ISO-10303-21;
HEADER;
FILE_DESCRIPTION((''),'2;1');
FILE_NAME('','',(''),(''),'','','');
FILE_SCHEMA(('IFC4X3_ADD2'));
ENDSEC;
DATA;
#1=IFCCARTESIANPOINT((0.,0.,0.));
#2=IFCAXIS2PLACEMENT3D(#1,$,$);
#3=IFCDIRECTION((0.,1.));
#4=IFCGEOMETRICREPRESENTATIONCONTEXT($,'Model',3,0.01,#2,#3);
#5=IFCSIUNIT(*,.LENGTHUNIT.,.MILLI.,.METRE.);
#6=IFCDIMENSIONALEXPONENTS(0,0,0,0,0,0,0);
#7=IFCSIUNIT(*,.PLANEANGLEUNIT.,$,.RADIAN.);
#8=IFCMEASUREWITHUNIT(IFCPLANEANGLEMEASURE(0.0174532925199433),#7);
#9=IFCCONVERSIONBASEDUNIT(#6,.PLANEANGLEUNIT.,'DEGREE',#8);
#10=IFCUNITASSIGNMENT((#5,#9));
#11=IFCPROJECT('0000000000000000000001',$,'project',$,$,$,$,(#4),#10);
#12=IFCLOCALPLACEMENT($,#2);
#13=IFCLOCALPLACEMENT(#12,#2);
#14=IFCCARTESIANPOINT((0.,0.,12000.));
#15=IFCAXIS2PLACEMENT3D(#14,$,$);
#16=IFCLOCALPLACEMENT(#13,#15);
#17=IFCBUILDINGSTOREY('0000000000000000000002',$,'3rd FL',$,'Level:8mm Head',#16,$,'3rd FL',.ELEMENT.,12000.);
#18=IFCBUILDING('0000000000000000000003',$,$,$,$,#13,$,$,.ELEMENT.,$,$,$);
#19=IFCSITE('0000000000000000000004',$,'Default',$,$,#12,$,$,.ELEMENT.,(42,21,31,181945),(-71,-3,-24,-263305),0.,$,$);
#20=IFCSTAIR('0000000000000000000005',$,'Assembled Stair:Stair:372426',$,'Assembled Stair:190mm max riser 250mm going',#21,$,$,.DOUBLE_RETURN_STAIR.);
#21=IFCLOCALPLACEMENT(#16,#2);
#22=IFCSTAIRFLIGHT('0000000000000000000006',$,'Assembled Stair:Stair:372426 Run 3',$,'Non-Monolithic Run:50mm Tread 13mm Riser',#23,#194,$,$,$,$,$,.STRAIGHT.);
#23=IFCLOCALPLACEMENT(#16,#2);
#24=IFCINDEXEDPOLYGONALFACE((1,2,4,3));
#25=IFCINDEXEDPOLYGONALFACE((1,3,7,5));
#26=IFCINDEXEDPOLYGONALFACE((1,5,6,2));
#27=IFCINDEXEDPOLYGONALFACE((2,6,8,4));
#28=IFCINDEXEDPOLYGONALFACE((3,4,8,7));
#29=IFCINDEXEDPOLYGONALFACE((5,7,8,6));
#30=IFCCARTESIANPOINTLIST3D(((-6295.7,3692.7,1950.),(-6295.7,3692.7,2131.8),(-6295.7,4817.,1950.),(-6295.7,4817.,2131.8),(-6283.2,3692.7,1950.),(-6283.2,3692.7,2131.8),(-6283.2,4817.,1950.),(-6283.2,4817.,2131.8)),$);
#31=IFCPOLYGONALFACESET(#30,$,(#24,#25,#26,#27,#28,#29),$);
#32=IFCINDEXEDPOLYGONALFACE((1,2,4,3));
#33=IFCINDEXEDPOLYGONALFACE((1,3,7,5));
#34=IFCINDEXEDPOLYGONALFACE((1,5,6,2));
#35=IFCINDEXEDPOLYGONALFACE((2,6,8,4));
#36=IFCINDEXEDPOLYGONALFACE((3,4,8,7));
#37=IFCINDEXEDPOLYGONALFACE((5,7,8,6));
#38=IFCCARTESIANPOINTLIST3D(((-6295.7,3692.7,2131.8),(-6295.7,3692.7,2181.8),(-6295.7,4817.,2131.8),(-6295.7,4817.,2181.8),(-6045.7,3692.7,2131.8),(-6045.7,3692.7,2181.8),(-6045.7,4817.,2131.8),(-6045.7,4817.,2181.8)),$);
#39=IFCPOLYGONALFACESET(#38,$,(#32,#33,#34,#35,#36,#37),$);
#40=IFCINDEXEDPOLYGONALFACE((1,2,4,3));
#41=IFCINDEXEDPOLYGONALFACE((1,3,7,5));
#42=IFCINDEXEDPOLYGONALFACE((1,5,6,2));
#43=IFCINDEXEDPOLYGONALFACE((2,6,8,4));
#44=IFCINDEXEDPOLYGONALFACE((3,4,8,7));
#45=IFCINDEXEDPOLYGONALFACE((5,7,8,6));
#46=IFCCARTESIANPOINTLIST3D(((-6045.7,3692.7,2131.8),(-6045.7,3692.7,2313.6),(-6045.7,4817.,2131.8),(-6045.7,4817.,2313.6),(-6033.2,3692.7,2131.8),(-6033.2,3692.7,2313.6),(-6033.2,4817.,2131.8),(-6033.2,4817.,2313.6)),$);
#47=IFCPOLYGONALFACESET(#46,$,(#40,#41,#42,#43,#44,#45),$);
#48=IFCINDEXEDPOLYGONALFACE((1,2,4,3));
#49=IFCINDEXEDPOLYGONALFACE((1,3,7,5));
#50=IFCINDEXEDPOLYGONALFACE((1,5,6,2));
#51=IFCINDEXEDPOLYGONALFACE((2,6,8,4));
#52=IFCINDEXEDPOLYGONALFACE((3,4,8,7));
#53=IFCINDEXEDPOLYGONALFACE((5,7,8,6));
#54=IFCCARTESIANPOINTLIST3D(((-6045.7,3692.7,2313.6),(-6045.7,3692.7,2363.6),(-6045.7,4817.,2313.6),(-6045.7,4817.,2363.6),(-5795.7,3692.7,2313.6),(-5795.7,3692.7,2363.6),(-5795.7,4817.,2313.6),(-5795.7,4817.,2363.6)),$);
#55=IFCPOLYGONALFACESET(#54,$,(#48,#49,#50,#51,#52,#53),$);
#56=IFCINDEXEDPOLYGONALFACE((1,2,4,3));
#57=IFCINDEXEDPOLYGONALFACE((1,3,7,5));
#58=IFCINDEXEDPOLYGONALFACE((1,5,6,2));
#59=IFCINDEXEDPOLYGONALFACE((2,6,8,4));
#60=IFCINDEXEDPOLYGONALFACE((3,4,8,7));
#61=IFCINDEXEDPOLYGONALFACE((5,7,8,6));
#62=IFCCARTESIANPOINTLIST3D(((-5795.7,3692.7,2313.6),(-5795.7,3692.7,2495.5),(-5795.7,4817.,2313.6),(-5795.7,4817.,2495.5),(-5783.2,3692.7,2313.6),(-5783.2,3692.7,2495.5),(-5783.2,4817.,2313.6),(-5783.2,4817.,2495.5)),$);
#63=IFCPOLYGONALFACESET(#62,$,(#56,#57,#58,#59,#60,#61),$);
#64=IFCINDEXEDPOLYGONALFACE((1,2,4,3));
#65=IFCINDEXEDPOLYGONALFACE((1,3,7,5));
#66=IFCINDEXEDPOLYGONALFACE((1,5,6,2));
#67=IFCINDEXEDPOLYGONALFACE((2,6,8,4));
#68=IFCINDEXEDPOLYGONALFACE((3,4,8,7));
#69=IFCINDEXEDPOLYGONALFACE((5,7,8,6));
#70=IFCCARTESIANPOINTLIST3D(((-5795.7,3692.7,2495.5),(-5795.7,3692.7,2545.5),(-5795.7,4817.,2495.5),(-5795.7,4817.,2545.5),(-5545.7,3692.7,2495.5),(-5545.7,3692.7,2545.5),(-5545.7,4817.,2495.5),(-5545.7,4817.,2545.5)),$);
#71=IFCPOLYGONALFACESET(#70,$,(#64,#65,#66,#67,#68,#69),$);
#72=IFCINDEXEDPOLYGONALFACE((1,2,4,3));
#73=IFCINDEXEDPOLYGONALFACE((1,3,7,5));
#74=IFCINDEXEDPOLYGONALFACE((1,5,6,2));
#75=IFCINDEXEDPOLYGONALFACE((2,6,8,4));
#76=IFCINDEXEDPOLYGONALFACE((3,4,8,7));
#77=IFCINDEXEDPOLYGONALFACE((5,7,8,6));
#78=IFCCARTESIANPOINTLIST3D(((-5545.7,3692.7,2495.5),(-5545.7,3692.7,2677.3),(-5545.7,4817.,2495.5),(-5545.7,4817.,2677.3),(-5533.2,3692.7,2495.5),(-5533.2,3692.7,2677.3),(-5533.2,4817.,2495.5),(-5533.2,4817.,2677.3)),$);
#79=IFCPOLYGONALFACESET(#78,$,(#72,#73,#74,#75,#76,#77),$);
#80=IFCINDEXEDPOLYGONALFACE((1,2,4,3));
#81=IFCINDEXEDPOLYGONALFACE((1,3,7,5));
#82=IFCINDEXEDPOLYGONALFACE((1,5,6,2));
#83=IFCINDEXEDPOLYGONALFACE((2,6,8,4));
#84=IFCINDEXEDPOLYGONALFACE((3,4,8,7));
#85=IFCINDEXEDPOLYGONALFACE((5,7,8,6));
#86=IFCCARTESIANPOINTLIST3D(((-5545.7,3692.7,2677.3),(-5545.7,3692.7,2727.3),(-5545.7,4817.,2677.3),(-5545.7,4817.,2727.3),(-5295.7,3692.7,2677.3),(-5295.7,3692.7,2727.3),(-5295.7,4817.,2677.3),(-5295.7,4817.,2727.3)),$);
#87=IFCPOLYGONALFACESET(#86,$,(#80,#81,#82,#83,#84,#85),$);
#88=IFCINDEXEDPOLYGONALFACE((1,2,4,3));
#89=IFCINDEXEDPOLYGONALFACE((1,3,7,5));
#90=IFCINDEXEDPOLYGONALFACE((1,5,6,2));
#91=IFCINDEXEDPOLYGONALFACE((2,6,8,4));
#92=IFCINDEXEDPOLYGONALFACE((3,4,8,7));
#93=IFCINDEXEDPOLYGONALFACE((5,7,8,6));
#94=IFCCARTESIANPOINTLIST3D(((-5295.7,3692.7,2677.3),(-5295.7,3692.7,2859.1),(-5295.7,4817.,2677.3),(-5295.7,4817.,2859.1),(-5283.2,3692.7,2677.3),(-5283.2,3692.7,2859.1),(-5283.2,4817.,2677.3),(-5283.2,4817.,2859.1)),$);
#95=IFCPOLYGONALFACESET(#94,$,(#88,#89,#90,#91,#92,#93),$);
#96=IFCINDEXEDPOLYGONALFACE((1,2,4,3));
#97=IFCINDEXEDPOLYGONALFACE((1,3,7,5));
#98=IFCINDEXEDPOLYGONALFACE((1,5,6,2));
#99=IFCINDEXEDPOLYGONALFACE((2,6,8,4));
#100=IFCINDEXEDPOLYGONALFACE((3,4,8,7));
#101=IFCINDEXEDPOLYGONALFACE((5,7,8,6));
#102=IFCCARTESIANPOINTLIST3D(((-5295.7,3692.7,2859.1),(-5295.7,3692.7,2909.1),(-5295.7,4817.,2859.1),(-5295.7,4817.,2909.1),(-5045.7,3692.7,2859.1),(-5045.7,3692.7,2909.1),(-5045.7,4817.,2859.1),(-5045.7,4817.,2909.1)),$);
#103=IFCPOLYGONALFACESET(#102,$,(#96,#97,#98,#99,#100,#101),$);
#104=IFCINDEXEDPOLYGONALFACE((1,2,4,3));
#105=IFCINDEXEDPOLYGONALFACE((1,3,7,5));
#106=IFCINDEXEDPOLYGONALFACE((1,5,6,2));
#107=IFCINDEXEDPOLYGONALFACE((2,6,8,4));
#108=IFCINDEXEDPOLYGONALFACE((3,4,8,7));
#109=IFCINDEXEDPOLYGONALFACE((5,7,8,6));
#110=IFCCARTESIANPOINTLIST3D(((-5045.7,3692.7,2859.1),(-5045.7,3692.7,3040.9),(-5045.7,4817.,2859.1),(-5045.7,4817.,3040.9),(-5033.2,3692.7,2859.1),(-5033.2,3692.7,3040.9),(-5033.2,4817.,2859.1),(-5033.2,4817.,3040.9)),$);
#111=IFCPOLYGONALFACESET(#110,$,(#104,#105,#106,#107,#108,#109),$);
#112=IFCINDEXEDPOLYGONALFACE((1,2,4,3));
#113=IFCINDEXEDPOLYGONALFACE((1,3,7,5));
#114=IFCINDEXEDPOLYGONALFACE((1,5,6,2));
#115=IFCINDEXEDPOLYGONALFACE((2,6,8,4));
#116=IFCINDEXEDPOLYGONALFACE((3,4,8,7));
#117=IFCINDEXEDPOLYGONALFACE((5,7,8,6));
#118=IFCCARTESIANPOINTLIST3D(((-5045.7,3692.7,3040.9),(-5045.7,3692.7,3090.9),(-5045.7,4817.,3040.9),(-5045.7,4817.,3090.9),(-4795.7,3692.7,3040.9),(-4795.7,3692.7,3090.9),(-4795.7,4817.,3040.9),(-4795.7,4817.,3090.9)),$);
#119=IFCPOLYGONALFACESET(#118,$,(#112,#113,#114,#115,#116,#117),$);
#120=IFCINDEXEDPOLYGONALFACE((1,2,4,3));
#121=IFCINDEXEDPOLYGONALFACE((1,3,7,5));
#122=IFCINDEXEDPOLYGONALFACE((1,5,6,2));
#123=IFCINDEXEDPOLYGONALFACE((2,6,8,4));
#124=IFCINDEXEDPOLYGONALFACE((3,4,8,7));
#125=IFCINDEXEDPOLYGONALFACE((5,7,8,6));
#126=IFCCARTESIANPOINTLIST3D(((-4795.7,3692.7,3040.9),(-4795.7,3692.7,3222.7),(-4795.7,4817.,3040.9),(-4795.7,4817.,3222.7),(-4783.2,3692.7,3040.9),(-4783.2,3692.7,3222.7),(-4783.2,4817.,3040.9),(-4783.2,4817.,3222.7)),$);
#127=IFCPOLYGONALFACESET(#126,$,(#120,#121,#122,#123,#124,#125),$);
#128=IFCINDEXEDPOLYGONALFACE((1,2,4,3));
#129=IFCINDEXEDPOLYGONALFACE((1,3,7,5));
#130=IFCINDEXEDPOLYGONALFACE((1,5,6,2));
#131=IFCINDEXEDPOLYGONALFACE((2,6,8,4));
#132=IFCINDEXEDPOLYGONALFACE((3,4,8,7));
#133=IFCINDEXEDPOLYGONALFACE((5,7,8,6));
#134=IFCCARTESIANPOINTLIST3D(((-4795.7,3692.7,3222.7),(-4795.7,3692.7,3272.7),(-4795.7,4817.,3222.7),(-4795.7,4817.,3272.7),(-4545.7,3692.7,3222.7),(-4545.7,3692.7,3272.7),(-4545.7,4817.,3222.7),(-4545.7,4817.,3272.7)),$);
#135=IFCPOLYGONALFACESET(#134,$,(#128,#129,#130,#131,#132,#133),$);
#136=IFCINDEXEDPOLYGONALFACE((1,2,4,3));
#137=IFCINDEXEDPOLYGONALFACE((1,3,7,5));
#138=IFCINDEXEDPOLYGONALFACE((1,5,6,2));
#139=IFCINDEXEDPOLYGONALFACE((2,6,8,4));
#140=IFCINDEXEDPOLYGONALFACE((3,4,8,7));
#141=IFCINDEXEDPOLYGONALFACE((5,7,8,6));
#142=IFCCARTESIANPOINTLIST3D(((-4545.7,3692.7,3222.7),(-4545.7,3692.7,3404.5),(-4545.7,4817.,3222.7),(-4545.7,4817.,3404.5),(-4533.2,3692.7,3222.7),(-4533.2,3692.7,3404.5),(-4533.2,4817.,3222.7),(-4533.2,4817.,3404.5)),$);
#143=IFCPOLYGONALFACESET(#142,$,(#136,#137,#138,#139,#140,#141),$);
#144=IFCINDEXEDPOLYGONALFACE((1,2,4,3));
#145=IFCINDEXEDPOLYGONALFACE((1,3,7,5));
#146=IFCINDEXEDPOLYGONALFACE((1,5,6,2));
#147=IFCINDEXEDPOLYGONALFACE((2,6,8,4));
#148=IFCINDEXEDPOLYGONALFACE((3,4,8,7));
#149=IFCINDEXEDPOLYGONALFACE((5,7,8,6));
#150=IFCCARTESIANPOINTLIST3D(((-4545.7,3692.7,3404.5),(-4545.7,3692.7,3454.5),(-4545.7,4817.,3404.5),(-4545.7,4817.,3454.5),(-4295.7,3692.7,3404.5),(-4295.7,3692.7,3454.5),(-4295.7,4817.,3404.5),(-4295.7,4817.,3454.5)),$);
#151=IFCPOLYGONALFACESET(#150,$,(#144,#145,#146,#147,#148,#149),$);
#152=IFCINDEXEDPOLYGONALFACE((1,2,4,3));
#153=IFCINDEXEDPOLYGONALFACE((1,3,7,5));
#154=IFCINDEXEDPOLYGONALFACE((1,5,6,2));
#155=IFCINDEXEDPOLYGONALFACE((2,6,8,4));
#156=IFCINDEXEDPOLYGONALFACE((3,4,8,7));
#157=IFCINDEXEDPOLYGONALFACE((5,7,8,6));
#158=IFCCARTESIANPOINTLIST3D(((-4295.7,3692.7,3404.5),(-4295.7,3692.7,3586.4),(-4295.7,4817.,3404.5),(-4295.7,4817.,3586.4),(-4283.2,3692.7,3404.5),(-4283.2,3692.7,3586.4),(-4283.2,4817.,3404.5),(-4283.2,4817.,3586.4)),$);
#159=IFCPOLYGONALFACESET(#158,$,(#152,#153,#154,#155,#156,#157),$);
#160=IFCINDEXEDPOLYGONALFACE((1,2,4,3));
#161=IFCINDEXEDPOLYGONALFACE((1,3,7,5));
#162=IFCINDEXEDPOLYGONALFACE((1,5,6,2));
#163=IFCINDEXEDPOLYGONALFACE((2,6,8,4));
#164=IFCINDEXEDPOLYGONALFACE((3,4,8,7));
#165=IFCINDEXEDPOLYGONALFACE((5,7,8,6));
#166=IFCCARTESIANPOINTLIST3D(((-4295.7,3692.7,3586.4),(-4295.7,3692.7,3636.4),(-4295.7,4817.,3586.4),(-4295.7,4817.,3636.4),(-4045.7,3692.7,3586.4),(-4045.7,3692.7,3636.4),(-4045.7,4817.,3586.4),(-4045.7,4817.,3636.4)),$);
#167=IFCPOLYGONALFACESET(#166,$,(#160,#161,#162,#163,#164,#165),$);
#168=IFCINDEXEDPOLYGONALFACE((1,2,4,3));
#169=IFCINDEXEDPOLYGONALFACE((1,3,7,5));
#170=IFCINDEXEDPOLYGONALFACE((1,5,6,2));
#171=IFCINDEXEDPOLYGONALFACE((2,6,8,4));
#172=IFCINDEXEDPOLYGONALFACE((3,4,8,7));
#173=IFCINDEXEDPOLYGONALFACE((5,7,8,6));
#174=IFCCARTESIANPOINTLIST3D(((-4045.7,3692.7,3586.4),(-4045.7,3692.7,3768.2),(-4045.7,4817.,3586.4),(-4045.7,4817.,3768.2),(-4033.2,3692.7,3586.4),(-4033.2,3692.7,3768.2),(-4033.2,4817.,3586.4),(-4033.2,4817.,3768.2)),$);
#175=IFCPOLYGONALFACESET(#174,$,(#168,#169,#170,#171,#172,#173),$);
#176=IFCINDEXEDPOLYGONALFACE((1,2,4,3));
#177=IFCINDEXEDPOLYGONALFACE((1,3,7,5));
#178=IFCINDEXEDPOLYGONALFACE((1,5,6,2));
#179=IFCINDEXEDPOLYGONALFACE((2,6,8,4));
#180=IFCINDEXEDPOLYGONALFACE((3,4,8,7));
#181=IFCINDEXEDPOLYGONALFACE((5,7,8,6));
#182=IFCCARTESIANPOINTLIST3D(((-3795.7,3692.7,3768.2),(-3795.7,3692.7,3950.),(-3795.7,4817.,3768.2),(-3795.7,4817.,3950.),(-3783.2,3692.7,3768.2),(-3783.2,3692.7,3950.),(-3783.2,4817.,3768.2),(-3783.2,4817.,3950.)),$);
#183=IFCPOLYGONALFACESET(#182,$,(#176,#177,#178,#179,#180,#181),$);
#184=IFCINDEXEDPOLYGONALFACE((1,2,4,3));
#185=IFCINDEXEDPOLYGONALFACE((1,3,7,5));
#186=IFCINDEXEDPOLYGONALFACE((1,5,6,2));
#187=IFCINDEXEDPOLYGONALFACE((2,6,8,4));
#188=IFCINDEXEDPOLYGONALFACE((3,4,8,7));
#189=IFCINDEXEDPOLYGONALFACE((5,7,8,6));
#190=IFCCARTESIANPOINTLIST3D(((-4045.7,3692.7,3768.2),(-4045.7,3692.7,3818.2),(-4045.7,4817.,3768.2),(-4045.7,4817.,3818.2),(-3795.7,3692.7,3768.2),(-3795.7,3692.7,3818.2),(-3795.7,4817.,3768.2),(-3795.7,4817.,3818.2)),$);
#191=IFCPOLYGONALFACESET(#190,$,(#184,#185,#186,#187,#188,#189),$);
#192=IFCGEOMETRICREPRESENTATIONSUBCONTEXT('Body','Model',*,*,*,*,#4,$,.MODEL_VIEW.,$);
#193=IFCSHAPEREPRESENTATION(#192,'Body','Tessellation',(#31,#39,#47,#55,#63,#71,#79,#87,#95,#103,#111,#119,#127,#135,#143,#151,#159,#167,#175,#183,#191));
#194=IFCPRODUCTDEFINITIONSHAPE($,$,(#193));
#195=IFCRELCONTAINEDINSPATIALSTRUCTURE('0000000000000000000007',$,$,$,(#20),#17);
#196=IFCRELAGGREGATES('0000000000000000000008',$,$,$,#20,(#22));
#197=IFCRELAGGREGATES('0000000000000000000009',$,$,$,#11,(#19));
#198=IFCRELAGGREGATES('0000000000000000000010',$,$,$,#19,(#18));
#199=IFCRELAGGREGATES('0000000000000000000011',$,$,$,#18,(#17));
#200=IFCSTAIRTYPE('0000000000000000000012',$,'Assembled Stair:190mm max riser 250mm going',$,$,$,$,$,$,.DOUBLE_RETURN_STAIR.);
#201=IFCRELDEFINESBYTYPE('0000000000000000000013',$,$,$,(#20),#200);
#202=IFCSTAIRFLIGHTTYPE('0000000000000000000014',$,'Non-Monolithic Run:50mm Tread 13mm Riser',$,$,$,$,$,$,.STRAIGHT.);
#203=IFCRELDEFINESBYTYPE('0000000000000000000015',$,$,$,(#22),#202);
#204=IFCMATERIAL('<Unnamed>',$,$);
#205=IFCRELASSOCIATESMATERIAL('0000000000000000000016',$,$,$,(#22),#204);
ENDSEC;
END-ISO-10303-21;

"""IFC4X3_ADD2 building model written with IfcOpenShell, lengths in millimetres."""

from ifc_helpers import new_model, entity, si_unit, converted_unit, direction, frame, frame_2d, origin, origin_2d_with_axis, place, context, subcontext, project, spatial, rectangle, extrude, material, type_object, element, aggregate, save


model = new_model("IFC4X3_ADD2")

# Units and contexts
model_context = context("Model", 3, precision=0.01, world=origin(), true_north=direction((0.0, 1.0)))
body_context = subcontext(model_context, "Body", "Model", "MODEL_VIEW")
ifc_project = project(units=[si_unit("LENGTHUNIT", "METRE", prefix="MILLI"), converted_unit("PLANEANGLEUNIT", "DEGREE", entity("IfcPlaneAngleMeasure", 0.0174532925199433), si_unit("PLANEANGLEUNIT", "RADIAN"), dimensions=[0, 0, 0, 0, 0, 0, 0])], contexts=[model_context])

# Site, building, storey
site_placement = place(None, origin())
site = spatial("IfcSite", under=ifc_project, at=site_placement, Name="Default", CompositionType="ELEMENT", RefLatitude=(42, 21, 31, 181945), RefLongitude=(-71, -3, -24, -263305), RefElevation=0.0)
building_placement = place(site_placement, origin())
building = spatial("IfcBuilding", under=site, at=building_placement, CompositionType="ELEMENT")
storey_placement = place(building_placement, frame((0.0, 0.0, 12000.0)))
storey = spatial("IfcBuildingStorey", under=building, at=storey_placement, Name="3rd FL", ObjectType="Level:8mm Head", LongName="3rd FL", CompositionType="ELEMENT", Elevation=12000.0)

# Stair
stair_type = type_object("IfcStairType", Name="Assembled Stair:190mm max riser 250mm going", PredefinedType="DOUBLE_RETURN_STAIR")
stair_placement = place(storey_placement, origin())
stair = element("IfcStair", 1, at=stair_placement, inside=storey, type_object=stair_type, Name="Assembled Stair:Stair:372426", ObjectType="Assembled Stair:190mm max riser 250mm going", PredefinedType="DOUBLE_RETURN_STAIR")
ifc_material_1 = material(Name="<Unnamed>")

# Stair flight
stair_flight_type = type_object("IfcStairFlightType", Name="Non-Monolithic Run:50mm Tread 13mm Riser", PredefinedType="STRAIGHT")
stair_flight_1_placement = place(stair_placement, frame((-6295.7, 3692.7, 0.0)))
stair_flight_1 = element("IfcStairFlight", 2, at=stair_flight_1_placement, type_object=stair_flight_type, material=ifc_material_1, Name="Assembled Stair:Stair:372426 Run 3", ObjectType="Non-Monolithic Run:50mm Tread 13mm Riser", PredefinedType="STRAIGHT", context=body_context, shape_type="SweptSolid", body=[
    extrude(rectangle(XDim=1124.3, YDim=12.5, at=frame_2d((0.0, 0.0), x_axis=(1.0, 0.0))), frame((6.3, 562.2, 1950.0), z_axis=(0.0, 0.0, 1.0), x_axis=(0.0, 1.0, 0.0)), (0.0, 0.0, 1.0), 181.8),
    extrude(rectangle(XDim=250.0, YDim=1124.3, at=frame_2d((0.0, 0.0), x_axis=(1.0, 0.0))), frame((125.0, 562.2, 2131.8), z_axis=(0.0, 0.0, 1.0), x_axis=(-1.0, 0.0, 0.0)), (0.0, 0.0, 1.0), 50.0),
    extrude(rectangle(XDim=1124.3, YDim=12.5, at=frame_2d((0.0, 0.0), x_axis=(1.0, 0.0))), frame((256.3, 562.2, 2131.8), z_axis=(0.0, 0.0, 1.0), x_axis=(0.0, 1.0, 0.0)), (0.0, 0.0, 1.0), 181.8),
    extrude(rectangle(XDim=250.0, YDim=1124.3, at=frame_2d((0.0, 0.0), x_axis=(1.0, 0.0))), frame((375.0, 562.2, 2313.6), z_axis=(0.0, 0.0, 1.0), x_axis=(-1.0, 0.0, 0.0)), (0.0, 0.0, 1.0), 50.0),
    extrude(rectangle(XDim=1124.3, YDim=12.5, at=frame_2d((0.0, 0.0), x_axis=(1.0, 0.0))), frame((506.3, 562.2, 2313.6), z_axis=(0.0, 0.0, 1.0), x_axis=(0.0, 1.0, 0.0)), (0.0, 0.0, 1.0), 181.8),
    extrude(rectangle(XDim=250.0, YDim=1124.3, at=frame_2d((0.0, 0.0), x_axis=(1.0, 0.0))), frame((625.0, 562.2, 2495.5), z_axis=(0.0, 0.0, 1.0), x_axis=(-1.0, 0.0, 0.0)), (0.0, 0.0, 1.0), 50.0),
    extrude(rectangle(XDim=1124.3, YDim=12.5, at=frame_2d((0.0, 0.0), x_axis=(1.0, 0.0))), frame((756.3, 562.2, 2495.5), z_axis=(0.0, 0.0, 1.0), x_axis=(0.0, 1.0, 0.0)), (0.0, 0.0, 1.0), 181.8),
    extrude(rectangle(XDim=250.0, YDim=1124.3, at=frame_2d((0.0, 0.0), x_axis=(1.0, 0.0))), frame((875.0, 562.2, 2677.3), z_axis=(0.0, 0.0, 1.0), x_axis=(-1.0, 0.0, 0.0)), (0.0, 0.0, 1.0), 50.0),
    extrude(rectangle(XDim=1124.3, YDim=12.5, at=frame_2d((0.0, 0.0), x_axis=(1.0, 0.0))), frame((1006.2, 562.2, 2677.3), z_axis=(0.0, 0.0, 1.0), x_axis=(0.0, 1.0, 0.0)), (0.0, 0.0, 1.0), 181.8),
    extrude(rectangle(XDim=250.0, YDim=1124.3, at=frame_2d((0.0, 0.0), x_axis=(1.0, 0.0))), frame((1125.0, 562.2, 2859.1), z_axis=(0.0, 0.0, 1.0), x_axis=(-1.0, 0.0, 0.0)), (0.0, 0.0, 1.0), 50.0),
    extrude(rectangle(XDim=1124.3, YDim=12.5, at=frame_2d((0.0, 0.0), x_axis=(1.0, 0.0))), frame((1256.2, 562.2, 2859.1), z_axis=(0.0, 0.0, 1.0), x_axis=(0.0, 1.0, 0.0)), (0.0, 0.0, 1.0), 181.8),
    extrude(rectangle(XDim=250.0, YDim=1124.3, at=frame_2d((0.0, 0.0), x_axis=(1.0, 0.0))), frame((1375.0, 562.2, 3040.9), z_axis=(0.0, 0.0, 1.0), x_axis=(-1.0, 0.0, 0.0)), (0.0, 0.0, 1.0), 50.0),
    extrude(rectangle(XDim=1124.3, YDim=12.5, at=frame_2d((0.0, 0.0), x_axis=(1.0, 0.0))), frame((1506.2, 562.2, 3040.9), z_axis=(0.0, 0.0, 1.0), x_axis=(0.0, 1.0, 0.0)), (0.0, 0.0, 1.0), 181.8),
    extrude(rectangle(XDim=250.0, YDim=1124.3, at=frame_2d((0.0, 0.0), x_axis=(1.0, 0.0))), frame((1625.0, 562.2, 3222.7), z_axis=(0.0, 0.0, 1.0), x_axis=(-1.0, 0.0, 0.0)), (0.0, 0.0, 1.0), 50.0),
    extrude(rectangle(XDim=1124.3, YDim=12.5, at=frame_2d((0.0, 0.0), x_axis=(1.0, 0.0))), frame((1756.2, 562.2, 3222.7), z_axis=(0.0, 0.0, 1.0), x_axis=(0.0, 1.0, 0.0)), (0.0, 0.0, 1.0), 181.8),
    extrude(rectangle(XDim=250.0, YDim=1124.3, at=frame_2d((0.0, 0.0), x_axis=(1.0, 0.0))), frame((1875.0, 562.2, 3404.5), z_axis=(0.0, 0.0, 1.0), x_axis=(-1.0, 0.0, 0.0)), (0.0, 0.0, 1.0), 50.0),
    extrude(rectangle(XDim=1124.3, YDim=12.5, at=origin_2d_with_axis()), frame((2006.2, 562.2, 3404.5), z_axis=(0.0, 0.0, 1.0), x_axis=(0.0, 1.0, 0.0)), (0.0, 0.0, 1.0), 181.8),
    extrude(rectangle(XDim=250.0, YDim=1124.3, at=frame_2d((0.0, 0.0), x_axis=(1.0, 0.0))), frame((2125.0, 562.2, 3586.4), z_axis=(0.0, 0.0, 1.0), x_axis=(-1.0, 0.0, 0.0)), (0.0, 0.0, 1.0), 50.0),
    extrude(rectangle(XDim=1124.3, YDim=12.5, at=frame_2d((0.0, 0.0), x_axis=(1.0, 0.0))), frame((2256.2, 562.2, 3586.4), z_axis=(0.0, 0.0, 1.0), x_axis=(0.0, 1.0, 0.0)), (0.0, 0.0, 1.0), 181.8),
    extrude(rectangle(XDim=1124.3, YDim=12.5, at=origin_2d_with_axis()), frame((2506.2, 562.2, 3768.2), z_axis=(0.0, 0.0, 1.0), x_axis=(0.0, 1.0, 0.0)), (0.0, 0.0, 1.0), 181.8),
    extrude(rectangle(XDim=250.0, YDim=1124.3, at=frame_2d((0.0, 0.0), x_axis=(1.0, 0.0))), frame((2375.0, 562.2, 3768.2), z_axis=(0.0, 0.0, 1.0), x_axis=(-1.0, 0.0, 0.0)), (0.0, 0.0, 1.0), 50.0),
])
aggregate(stair, [stair_flight_1])

save(model, "model.ifc")
